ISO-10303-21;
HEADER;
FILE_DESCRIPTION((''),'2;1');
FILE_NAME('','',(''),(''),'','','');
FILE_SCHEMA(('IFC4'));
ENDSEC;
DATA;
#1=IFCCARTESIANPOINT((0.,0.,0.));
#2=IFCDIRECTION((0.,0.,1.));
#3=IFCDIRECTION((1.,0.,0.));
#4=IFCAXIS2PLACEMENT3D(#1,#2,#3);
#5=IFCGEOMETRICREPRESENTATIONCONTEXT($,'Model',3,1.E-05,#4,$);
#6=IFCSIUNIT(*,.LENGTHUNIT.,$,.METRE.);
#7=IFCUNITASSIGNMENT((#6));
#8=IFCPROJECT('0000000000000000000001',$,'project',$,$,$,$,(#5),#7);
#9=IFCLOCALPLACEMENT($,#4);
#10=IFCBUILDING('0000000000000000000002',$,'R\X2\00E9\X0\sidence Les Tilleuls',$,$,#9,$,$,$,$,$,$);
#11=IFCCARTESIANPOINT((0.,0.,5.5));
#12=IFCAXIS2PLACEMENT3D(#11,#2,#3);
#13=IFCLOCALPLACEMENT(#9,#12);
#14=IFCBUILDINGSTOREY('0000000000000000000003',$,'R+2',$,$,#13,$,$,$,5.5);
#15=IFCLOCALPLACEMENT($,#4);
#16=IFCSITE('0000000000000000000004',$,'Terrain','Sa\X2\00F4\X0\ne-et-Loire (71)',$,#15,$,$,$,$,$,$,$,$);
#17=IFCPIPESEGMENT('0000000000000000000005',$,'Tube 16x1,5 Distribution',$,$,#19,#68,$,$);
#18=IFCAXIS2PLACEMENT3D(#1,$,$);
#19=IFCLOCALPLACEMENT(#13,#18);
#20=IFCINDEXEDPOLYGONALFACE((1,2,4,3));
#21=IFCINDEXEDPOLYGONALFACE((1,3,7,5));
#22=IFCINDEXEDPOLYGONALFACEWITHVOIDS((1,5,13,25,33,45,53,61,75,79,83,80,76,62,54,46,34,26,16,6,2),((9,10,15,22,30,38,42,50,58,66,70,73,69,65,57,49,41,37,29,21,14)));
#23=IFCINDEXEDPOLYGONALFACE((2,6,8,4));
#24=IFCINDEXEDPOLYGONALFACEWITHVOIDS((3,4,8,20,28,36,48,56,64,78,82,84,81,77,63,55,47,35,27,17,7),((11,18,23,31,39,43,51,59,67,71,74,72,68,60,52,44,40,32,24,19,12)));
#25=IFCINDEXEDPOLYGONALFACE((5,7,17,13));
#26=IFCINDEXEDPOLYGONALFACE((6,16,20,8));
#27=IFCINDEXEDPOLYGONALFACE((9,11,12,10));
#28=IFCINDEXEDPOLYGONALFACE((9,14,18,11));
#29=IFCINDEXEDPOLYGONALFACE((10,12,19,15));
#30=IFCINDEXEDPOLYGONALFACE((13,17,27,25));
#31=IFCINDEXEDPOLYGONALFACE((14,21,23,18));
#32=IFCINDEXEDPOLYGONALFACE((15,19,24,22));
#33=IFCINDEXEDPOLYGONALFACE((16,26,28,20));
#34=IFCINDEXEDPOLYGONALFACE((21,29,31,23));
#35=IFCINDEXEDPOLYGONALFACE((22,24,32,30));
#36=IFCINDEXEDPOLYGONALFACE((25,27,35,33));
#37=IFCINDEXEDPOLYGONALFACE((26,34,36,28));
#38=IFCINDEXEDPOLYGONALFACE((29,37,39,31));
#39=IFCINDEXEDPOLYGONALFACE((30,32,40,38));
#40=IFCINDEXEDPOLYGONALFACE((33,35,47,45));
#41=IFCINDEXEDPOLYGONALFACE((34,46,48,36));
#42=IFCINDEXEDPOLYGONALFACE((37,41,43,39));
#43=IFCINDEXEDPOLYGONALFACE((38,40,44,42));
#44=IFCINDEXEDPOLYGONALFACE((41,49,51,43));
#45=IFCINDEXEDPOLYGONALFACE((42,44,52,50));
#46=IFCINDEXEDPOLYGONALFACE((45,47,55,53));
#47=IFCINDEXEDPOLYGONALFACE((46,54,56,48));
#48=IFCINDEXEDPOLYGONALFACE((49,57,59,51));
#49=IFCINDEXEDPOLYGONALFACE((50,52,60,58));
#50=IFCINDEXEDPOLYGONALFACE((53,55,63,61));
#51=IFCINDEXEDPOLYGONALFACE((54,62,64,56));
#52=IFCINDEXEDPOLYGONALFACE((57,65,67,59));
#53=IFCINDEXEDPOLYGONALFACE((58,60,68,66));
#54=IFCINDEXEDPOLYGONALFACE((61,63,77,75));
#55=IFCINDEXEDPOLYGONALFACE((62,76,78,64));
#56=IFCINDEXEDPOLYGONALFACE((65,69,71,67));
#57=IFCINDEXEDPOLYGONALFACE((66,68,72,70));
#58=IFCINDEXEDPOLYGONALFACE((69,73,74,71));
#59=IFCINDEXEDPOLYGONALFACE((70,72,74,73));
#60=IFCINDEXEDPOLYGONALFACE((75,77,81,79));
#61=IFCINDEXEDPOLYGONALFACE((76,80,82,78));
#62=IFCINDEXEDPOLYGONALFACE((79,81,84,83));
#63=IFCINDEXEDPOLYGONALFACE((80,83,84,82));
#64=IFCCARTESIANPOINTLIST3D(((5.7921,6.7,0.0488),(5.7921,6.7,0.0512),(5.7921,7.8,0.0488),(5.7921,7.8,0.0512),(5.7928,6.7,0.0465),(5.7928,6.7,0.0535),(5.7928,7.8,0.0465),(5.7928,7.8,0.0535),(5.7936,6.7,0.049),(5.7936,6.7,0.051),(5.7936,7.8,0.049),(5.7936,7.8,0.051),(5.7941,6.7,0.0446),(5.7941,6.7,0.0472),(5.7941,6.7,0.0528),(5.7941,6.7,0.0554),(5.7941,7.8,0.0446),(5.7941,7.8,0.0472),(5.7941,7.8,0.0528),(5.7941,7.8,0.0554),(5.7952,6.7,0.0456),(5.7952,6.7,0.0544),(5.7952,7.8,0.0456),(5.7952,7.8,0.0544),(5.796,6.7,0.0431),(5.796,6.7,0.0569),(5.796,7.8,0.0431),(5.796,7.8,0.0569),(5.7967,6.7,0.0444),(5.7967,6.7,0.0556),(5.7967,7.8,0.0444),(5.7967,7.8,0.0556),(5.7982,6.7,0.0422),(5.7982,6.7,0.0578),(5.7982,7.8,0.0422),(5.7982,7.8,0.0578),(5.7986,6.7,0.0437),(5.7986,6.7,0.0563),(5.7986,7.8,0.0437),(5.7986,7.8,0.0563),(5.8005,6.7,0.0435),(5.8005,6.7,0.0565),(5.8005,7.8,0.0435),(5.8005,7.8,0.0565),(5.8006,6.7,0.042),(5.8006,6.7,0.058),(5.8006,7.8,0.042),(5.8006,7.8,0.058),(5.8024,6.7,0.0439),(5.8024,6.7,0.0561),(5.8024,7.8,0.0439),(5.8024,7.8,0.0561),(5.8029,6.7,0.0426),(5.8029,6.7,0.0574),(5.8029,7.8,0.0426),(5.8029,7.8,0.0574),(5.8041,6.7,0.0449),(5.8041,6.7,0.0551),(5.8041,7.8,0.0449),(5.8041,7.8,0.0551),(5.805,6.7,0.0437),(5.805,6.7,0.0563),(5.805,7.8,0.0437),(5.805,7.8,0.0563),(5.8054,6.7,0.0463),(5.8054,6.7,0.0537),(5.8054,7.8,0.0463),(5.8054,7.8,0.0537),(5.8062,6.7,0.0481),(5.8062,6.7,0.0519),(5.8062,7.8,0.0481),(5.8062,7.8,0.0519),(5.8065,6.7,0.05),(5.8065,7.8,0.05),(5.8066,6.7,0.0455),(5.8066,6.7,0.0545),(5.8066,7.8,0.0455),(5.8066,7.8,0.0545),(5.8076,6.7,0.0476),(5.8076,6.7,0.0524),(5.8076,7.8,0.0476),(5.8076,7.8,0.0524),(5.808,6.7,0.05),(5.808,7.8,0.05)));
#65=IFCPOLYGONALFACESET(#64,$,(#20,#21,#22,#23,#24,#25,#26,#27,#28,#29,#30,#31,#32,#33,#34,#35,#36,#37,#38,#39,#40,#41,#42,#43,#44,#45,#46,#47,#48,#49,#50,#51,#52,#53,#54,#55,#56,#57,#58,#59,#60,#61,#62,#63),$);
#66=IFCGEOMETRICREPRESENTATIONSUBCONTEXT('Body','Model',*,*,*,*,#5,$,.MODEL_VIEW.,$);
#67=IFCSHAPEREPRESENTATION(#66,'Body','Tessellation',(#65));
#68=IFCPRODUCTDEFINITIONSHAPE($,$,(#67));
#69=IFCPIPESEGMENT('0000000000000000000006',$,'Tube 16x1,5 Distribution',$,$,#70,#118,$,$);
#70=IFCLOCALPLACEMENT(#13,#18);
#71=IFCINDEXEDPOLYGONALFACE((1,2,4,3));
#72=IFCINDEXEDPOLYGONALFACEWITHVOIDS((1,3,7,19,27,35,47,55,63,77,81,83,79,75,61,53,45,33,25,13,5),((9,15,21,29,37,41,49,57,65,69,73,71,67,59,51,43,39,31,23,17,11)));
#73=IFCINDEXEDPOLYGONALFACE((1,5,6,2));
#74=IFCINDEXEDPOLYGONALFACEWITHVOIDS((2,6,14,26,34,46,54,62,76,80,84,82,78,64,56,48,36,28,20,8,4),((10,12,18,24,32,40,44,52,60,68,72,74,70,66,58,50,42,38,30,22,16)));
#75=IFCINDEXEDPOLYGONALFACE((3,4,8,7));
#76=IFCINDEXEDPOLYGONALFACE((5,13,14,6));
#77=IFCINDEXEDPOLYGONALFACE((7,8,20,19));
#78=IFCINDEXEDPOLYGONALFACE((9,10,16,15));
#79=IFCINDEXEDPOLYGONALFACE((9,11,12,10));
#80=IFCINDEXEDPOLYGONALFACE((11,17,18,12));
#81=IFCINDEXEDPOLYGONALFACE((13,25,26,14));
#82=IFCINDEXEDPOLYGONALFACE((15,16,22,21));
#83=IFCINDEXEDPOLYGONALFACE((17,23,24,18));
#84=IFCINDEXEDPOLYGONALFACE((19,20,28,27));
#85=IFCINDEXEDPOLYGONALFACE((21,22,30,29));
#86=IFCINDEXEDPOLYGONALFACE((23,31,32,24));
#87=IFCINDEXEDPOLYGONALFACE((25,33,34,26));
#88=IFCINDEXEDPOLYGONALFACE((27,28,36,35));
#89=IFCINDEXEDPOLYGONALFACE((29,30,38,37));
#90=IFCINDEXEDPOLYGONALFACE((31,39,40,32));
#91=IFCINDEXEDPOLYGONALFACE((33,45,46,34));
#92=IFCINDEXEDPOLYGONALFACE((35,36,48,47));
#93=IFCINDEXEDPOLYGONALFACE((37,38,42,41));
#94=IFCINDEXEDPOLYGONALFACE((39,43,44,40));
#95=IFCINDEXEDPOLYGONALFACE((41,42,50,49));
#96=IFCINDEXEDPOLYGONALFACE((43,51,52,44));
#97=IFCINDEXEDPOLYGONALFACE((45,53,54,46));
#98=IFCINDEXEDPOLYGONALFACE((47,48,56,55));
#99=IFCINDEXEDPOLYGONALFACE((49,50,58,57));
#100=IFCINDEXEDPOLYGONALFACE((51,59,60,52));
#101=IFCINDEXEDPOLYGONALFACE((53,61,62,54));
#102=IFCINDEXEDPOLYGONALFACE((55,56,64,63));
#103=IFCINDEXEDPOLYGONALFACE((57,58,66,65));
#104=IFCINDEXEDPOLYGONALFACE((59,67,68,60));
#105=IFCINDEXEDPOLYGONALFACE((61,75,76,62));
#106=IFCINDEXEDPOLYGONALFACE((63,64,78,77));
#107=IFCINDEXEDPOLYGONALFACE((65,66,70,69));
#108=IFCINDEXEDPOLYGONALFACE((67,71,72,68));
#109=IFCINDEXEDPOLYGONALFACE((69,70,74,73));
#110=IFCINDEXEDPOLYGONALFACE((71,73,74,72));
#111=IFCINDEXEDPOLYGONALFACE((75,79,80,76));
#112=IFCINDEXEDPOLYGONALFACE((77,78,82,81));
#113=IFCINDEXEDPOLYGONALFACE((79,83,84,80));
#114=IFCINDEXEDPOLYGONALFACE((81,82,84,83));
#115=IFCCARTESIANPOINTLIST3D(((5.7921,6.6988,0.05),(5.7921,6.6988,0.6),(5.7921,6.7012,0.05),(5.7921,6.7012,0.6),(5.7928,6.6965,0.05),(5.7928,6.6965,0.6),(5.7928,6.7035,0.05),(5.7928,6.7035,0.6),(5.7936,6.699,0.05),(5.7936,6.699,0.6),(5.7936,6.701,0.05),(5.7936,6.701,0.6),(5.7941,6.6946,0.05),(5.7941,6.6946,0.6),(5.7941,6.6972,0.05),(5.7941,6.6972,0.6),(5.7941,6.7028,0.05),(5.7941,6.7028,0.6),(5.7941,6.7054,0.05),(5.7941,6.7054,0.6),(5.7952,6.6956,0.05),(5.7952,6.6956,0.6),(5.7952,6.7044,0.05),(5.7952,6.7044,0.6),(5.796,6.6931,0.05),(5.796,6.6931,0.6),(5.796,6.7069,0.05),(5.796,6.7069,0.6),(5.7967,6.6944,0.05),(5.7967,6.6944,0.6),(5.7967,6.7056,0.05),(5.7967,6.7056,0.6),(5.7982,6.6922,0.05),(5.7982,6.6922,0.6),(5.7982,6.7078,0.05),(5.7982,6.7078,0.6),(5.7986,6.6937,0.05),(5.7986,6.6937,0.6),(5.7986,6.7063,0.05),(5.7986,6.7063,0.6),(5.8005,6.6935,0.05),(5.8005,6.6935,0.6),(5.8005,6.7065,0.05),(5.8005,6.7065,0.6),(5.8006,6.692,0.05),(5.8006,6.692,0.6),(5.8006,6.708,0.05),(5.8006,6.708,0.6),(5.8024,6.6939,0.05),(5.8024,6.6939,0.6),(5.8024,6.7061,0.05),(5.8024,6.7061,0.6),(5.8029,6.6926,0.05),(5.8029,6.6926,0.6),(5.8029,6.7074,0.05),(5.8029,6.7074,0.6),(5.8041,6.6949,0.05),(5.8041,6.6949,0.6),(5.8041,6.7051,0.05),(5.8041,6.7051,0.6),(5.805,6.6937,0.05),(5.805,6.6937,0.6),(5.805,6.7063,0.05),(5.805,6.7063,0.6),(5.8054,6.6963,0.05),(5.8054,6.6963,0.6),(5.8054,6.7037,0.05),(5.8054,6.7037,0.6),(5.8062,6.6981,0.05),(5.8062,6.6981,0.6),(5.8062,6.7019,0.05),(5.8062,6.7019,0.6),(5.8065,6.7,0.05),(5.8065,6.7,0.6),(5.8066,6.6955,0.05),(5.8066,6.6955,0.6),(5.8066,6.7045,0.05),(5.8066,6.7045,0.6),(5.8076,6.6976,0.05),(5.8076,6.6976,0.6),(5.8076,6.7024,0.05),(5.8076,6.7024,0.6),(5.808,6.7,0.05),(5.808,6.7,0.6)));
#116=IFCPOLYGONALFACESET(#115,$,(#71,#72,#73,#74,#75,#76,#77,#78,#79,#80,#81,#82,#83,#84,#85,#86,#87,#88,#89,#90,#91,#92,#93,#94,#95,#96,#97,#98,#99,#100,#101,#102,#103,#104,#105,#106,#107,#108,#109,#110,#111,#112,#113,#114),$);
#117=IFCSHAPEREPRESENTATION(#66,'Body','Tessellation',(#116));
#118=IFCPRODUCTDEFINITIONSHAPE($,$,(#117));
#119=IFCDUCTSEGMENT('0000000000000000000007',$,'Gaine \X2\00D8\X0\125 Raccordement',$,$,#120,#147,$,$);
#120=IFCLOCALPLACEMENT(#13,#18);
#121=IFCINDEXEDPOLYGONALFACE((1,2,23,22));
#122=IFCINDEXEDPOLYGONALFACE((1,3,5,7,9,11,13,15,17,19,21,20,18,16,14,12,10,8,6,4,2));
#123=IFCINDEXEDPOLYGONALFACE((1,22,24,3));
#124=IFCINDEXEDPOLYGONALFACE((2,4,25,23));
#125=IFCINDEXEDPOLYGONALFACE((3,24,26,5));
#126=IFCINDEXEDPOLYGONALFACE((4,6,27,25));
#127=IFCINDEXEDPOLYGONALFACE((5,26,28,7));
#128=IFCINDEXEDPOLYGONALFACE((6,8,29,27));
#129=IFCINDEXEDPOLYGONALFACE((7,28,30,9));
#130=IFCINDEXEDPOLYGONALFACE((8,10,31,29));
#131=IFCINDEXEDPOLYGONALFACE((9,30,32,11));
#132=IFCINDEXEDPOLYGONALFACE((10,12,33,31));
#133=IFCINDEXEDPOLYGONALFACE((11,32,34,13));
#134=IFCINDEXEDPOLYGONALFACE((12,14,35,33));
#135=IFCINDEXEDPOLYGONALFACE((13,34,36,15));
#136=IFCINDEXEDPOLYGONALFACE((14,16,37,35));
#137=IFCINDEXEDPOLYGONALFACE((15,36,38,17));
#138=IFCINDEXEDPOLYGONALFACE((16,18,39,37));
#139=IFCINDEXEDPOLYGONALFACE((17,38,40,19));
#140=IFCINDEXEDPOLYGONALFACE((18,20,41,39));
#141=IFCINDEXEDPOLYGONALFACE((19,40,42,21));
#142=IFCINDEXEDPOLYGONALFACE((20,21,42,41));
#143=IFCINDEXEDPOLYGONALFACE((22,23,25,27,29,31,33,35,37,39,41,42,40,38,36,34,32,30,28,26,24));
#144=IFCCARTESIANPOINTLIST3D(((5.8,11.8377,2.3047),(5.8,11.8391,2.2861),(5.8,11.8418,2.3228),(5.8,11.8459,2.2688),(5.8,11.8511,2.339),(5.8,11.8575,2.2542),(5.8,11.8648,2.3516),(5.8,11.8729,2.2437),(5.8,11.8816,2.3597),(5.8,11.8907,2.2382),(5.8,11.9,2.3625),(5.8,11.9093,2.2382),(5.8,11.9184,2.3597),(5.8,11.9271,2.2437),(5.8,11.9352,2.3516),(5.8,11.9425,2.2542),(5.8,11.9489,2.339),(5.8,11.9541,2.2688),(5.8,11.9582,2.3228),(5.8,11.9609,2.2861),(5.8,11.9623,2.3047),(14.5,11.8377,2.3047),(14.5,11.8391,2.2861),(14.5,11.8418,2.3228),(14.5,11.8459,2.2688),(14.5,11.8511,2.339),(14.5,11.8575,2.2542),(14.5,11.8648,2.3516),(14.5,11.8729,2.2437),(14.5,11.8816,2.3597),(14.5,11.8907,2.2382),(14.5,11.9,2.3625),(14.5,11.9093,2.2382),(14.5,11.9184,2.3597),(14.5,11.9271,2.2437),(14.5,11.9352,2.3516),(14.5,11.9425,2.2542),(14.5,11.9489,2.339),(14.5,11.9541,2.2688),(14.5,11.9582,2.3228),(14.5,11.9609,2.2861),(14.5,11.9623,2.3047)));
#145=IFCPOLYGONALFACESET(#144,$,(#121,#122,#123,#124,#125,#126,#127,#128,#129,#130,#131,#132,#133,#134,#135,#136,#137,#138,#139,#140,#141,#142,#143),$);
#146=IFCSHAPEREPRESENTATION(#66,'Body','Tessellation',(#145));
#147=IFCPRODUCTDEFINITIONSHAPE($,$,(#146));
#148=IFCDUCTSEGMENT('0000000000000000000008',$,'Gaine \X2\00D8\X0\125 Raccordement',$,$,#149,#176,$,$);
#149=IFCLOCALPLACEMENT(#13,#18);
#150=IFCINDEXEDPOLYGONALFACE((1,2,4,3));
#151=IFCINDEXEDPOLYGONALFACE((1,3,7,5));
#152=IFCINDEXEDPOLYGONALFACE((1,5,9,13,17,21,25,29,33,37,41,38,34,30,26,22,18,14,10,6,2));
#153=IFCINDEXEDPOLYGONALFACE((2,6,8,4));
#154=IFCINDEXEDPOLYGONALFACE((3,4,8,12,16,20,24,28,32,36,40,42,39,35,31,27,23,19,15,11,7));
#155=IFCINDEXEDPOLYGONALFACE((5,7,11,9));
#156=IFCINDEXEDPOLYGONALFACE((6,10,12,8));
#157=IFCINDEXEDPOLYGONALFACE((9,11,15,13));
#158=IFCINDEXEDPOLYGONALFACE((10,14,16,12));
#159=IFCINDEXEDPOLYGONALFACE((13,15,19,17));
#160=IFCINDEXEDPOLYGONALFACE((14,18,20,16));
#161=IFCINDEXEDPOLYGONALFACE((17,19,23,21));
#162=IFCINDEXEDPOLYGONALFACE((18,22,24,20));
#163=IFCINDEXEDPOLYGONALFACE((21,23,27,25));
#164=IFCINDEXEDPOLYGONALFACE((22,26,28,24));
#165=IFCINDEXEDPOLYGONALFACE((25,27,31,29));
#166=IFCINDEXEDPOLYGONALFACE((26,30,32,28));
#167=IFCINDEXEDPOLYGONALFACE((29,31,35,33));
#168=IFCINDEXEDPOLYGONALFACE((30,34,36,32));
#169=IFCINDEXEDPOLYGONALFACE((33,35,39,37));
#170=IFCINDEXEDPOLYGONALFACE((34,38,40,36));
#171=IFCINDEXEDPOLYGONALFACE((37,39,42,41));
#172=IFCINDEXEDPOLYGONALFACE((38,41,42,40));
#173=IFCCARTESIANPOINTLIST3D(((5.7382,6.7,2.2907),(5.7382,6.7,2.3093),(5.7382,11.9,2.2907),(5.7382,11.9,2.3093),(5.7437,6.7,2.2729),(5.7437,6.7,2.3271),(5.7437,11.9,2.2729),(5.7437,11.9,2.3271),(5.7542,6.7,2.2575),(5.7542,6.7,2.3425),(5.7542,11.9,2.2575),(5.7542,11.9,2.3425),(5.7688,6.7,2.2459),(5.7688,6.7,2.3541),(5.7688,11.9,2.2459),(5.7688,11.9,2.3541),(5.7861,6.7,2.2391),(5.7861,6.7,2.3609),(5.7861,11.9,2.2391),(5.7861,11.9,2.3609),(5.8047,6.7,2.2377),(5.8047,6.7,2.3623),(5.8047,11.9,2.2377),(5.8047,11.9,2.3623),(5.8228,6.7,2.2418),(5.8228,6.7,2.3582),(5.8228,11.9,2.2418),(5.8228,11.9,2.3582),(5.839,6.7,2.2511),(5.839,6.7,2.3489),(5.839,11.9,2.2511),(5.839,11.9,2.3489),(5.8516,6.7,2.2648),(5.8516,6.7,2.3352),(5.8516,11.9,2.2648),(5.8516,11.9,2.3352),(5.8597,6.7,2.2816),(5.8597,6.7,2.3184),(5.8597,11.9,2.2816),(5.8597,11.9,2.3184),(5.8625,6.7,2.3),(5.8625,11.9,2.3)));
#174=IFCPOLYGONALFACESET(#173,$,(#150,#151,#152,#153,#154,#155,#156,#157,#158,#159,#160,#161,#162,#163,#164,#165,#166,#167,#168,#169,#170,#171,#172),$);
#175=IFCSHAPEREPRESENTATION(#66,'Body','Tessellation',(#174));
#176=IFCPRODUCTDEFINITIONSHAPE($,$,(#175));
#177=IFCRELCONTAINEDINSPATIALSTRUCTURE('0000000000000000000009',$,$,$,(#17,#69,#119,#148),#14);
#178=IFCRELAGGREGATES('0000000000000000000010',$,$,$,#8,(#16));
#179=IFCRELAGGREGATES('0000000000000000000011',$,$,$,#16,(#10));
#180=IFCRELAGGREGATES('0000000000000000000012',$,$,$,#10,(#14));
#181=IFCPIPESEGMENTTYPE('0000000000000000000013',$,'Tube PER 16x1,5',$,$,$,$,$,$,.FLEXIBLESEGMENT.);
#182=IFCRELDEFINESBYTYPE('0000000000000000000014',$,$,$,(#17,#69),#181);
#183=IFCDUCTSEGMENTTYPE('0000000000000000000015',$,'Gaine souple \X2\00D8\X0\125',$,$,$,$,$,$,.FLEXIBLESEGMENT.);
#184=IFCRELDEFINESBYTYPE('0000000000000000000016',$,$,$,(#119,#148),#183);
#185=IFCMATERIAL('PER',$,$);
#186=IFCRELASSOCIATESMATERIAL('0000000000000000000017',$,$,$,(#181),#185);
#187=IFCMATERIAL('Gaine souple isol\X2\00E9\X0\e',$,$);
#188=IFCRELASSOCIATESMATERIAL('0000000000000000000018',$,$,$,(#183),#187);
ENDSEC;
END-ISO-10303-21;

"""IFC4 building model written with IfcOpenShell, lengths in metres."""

from ifc_helpers import new_model, si_unit, frame, origin_with_axes, place, context, subcontext, project, spatial, circle, hollow_circle, extrude, material, type_object, element, save


model = new_model("IFC4")

# Units and contexts
model_context = context("Model", 3, precision=1e-05, world=origin_with_axes())
body_context = subcontext(model_context, "Body", "Model", "MODEL_VIEW")
ifc_project = project(units=[si_unit("LENGTHUNIT", "METRE")], contexts=[model_context])

# Site, building, storey
site_placement = place(None, origin_with_axes())
site = spatial("IfcSite", under=ifc_project, at=site_placement, Name="Terrain", Description="Saône-et-Loire (71)")
building_placement = place(None, origin_with_axes())
building = spatial("IfcBuilding", under=site, at=building_placement, Name="Résidence Les Tilleuls")
storey_placement = place(building_placement, frame((0.0, 0.0, 5.5), z_axis=(0.0, 0.0, 1.0), x_axis=(1.0, 0.0, 0.0)))
storey = spatial("IfcBuildingStorey", under=building, at=storey_placement, Name="R+2", Elevation=5.5)

# Pipe segments
ifc_material_1 = material(Name="PER")
pipe_segment_type_1 = type_object("IfcPipeSegmentType", Name="Tube PER 16x1,5", PredefinedType="FLEXIBLESEGMENT", material=ifc_material_1)
pipe_segment_1_placement = place(storey_placement, frame((5.8, 7.8, 0.05), z_axis=(0.0, -1.0, 0.0), x_axis=(1.0, 0.0, 0.0)))
element("IfcPipeSegment", 1, at=pipe_segment_1_placement, inside=storey, type_object=pipe_segment_type_1, Name="Tube 16x1,5 Distribution", context=body_context, shape_type="SweptSolid", body=[
    extrude(hollow_circle(Radius=0.008, WallThickness=0.0015), origin_with_axes(), (0.0, 0.0, 1.0), 1.1),
])
pipe_segment_2_placement = place(storey_placement, frame((5.8, 6.7, 0.05), z_axis=(0.0, 0.0, 1.0), x_axis=(1.0, 0.0, 0.0)))
element("IfcPipeSegment", 2, at=pipe_segment_2_placement, inside=storey, type_object=pipe_segment_type_1, Name="Tube 16x1,5 Distribution", context=body_context, shape_type="SweptSolid", body=[
    extrude(hollow_circle(Radius=0.008, WallThickness=0.0015), origin_with_axes(), (0.0, 0.0, 1.0), 0.55),
])

# Duct segments
ifc_material_2 = material(Name="Gaine souple isolée")
duct_segment_type = type_object("IfcDuctSegmentType", Name="Gaine souple Ø125", PredefinedType="FLEXIBLESEGMENT", material=ifc_material_2)
duct_segment_1_placement = place(storey_placement, frame((5.8, 11.9, 2.3), z_axis=(1.0, 0.0, 0.0), x_axis=(0.0, 0.0, 1.0)))
element("IfcDuctSegment", 3, at=duct_segment_1_placement, inside=storey, type_object=duct_segment_type, Name="Gaine Ø125 Raccordement", context=body_context, shape_type="SweptSolid", body=[
    extrude(circle(Radius=0.0625), origin_with_axes(), (0.0, 0.0, 1.0), 8.7),
])
duct_segment_2_placement = place(storey_placement, frame((5.8, 6.7, 2.3), z_axis=(0.0, 1.0, 0.0), x_axis=(1.0, 0.0, 0.0)))
element("IfcDuctSegment", 4, at=duct_segment_2_placement, inside=storey, type_object=duct_segment_type, Name="Gaine Ø125 Raccordement", context=body_context, shape_type="SweptSolid", body=[
    extrude(circle(Radius=0.0625), origin_with_axes(), (0.0, 0.0, 1.0), 5.2),
])

save(model, "model.ifc")
